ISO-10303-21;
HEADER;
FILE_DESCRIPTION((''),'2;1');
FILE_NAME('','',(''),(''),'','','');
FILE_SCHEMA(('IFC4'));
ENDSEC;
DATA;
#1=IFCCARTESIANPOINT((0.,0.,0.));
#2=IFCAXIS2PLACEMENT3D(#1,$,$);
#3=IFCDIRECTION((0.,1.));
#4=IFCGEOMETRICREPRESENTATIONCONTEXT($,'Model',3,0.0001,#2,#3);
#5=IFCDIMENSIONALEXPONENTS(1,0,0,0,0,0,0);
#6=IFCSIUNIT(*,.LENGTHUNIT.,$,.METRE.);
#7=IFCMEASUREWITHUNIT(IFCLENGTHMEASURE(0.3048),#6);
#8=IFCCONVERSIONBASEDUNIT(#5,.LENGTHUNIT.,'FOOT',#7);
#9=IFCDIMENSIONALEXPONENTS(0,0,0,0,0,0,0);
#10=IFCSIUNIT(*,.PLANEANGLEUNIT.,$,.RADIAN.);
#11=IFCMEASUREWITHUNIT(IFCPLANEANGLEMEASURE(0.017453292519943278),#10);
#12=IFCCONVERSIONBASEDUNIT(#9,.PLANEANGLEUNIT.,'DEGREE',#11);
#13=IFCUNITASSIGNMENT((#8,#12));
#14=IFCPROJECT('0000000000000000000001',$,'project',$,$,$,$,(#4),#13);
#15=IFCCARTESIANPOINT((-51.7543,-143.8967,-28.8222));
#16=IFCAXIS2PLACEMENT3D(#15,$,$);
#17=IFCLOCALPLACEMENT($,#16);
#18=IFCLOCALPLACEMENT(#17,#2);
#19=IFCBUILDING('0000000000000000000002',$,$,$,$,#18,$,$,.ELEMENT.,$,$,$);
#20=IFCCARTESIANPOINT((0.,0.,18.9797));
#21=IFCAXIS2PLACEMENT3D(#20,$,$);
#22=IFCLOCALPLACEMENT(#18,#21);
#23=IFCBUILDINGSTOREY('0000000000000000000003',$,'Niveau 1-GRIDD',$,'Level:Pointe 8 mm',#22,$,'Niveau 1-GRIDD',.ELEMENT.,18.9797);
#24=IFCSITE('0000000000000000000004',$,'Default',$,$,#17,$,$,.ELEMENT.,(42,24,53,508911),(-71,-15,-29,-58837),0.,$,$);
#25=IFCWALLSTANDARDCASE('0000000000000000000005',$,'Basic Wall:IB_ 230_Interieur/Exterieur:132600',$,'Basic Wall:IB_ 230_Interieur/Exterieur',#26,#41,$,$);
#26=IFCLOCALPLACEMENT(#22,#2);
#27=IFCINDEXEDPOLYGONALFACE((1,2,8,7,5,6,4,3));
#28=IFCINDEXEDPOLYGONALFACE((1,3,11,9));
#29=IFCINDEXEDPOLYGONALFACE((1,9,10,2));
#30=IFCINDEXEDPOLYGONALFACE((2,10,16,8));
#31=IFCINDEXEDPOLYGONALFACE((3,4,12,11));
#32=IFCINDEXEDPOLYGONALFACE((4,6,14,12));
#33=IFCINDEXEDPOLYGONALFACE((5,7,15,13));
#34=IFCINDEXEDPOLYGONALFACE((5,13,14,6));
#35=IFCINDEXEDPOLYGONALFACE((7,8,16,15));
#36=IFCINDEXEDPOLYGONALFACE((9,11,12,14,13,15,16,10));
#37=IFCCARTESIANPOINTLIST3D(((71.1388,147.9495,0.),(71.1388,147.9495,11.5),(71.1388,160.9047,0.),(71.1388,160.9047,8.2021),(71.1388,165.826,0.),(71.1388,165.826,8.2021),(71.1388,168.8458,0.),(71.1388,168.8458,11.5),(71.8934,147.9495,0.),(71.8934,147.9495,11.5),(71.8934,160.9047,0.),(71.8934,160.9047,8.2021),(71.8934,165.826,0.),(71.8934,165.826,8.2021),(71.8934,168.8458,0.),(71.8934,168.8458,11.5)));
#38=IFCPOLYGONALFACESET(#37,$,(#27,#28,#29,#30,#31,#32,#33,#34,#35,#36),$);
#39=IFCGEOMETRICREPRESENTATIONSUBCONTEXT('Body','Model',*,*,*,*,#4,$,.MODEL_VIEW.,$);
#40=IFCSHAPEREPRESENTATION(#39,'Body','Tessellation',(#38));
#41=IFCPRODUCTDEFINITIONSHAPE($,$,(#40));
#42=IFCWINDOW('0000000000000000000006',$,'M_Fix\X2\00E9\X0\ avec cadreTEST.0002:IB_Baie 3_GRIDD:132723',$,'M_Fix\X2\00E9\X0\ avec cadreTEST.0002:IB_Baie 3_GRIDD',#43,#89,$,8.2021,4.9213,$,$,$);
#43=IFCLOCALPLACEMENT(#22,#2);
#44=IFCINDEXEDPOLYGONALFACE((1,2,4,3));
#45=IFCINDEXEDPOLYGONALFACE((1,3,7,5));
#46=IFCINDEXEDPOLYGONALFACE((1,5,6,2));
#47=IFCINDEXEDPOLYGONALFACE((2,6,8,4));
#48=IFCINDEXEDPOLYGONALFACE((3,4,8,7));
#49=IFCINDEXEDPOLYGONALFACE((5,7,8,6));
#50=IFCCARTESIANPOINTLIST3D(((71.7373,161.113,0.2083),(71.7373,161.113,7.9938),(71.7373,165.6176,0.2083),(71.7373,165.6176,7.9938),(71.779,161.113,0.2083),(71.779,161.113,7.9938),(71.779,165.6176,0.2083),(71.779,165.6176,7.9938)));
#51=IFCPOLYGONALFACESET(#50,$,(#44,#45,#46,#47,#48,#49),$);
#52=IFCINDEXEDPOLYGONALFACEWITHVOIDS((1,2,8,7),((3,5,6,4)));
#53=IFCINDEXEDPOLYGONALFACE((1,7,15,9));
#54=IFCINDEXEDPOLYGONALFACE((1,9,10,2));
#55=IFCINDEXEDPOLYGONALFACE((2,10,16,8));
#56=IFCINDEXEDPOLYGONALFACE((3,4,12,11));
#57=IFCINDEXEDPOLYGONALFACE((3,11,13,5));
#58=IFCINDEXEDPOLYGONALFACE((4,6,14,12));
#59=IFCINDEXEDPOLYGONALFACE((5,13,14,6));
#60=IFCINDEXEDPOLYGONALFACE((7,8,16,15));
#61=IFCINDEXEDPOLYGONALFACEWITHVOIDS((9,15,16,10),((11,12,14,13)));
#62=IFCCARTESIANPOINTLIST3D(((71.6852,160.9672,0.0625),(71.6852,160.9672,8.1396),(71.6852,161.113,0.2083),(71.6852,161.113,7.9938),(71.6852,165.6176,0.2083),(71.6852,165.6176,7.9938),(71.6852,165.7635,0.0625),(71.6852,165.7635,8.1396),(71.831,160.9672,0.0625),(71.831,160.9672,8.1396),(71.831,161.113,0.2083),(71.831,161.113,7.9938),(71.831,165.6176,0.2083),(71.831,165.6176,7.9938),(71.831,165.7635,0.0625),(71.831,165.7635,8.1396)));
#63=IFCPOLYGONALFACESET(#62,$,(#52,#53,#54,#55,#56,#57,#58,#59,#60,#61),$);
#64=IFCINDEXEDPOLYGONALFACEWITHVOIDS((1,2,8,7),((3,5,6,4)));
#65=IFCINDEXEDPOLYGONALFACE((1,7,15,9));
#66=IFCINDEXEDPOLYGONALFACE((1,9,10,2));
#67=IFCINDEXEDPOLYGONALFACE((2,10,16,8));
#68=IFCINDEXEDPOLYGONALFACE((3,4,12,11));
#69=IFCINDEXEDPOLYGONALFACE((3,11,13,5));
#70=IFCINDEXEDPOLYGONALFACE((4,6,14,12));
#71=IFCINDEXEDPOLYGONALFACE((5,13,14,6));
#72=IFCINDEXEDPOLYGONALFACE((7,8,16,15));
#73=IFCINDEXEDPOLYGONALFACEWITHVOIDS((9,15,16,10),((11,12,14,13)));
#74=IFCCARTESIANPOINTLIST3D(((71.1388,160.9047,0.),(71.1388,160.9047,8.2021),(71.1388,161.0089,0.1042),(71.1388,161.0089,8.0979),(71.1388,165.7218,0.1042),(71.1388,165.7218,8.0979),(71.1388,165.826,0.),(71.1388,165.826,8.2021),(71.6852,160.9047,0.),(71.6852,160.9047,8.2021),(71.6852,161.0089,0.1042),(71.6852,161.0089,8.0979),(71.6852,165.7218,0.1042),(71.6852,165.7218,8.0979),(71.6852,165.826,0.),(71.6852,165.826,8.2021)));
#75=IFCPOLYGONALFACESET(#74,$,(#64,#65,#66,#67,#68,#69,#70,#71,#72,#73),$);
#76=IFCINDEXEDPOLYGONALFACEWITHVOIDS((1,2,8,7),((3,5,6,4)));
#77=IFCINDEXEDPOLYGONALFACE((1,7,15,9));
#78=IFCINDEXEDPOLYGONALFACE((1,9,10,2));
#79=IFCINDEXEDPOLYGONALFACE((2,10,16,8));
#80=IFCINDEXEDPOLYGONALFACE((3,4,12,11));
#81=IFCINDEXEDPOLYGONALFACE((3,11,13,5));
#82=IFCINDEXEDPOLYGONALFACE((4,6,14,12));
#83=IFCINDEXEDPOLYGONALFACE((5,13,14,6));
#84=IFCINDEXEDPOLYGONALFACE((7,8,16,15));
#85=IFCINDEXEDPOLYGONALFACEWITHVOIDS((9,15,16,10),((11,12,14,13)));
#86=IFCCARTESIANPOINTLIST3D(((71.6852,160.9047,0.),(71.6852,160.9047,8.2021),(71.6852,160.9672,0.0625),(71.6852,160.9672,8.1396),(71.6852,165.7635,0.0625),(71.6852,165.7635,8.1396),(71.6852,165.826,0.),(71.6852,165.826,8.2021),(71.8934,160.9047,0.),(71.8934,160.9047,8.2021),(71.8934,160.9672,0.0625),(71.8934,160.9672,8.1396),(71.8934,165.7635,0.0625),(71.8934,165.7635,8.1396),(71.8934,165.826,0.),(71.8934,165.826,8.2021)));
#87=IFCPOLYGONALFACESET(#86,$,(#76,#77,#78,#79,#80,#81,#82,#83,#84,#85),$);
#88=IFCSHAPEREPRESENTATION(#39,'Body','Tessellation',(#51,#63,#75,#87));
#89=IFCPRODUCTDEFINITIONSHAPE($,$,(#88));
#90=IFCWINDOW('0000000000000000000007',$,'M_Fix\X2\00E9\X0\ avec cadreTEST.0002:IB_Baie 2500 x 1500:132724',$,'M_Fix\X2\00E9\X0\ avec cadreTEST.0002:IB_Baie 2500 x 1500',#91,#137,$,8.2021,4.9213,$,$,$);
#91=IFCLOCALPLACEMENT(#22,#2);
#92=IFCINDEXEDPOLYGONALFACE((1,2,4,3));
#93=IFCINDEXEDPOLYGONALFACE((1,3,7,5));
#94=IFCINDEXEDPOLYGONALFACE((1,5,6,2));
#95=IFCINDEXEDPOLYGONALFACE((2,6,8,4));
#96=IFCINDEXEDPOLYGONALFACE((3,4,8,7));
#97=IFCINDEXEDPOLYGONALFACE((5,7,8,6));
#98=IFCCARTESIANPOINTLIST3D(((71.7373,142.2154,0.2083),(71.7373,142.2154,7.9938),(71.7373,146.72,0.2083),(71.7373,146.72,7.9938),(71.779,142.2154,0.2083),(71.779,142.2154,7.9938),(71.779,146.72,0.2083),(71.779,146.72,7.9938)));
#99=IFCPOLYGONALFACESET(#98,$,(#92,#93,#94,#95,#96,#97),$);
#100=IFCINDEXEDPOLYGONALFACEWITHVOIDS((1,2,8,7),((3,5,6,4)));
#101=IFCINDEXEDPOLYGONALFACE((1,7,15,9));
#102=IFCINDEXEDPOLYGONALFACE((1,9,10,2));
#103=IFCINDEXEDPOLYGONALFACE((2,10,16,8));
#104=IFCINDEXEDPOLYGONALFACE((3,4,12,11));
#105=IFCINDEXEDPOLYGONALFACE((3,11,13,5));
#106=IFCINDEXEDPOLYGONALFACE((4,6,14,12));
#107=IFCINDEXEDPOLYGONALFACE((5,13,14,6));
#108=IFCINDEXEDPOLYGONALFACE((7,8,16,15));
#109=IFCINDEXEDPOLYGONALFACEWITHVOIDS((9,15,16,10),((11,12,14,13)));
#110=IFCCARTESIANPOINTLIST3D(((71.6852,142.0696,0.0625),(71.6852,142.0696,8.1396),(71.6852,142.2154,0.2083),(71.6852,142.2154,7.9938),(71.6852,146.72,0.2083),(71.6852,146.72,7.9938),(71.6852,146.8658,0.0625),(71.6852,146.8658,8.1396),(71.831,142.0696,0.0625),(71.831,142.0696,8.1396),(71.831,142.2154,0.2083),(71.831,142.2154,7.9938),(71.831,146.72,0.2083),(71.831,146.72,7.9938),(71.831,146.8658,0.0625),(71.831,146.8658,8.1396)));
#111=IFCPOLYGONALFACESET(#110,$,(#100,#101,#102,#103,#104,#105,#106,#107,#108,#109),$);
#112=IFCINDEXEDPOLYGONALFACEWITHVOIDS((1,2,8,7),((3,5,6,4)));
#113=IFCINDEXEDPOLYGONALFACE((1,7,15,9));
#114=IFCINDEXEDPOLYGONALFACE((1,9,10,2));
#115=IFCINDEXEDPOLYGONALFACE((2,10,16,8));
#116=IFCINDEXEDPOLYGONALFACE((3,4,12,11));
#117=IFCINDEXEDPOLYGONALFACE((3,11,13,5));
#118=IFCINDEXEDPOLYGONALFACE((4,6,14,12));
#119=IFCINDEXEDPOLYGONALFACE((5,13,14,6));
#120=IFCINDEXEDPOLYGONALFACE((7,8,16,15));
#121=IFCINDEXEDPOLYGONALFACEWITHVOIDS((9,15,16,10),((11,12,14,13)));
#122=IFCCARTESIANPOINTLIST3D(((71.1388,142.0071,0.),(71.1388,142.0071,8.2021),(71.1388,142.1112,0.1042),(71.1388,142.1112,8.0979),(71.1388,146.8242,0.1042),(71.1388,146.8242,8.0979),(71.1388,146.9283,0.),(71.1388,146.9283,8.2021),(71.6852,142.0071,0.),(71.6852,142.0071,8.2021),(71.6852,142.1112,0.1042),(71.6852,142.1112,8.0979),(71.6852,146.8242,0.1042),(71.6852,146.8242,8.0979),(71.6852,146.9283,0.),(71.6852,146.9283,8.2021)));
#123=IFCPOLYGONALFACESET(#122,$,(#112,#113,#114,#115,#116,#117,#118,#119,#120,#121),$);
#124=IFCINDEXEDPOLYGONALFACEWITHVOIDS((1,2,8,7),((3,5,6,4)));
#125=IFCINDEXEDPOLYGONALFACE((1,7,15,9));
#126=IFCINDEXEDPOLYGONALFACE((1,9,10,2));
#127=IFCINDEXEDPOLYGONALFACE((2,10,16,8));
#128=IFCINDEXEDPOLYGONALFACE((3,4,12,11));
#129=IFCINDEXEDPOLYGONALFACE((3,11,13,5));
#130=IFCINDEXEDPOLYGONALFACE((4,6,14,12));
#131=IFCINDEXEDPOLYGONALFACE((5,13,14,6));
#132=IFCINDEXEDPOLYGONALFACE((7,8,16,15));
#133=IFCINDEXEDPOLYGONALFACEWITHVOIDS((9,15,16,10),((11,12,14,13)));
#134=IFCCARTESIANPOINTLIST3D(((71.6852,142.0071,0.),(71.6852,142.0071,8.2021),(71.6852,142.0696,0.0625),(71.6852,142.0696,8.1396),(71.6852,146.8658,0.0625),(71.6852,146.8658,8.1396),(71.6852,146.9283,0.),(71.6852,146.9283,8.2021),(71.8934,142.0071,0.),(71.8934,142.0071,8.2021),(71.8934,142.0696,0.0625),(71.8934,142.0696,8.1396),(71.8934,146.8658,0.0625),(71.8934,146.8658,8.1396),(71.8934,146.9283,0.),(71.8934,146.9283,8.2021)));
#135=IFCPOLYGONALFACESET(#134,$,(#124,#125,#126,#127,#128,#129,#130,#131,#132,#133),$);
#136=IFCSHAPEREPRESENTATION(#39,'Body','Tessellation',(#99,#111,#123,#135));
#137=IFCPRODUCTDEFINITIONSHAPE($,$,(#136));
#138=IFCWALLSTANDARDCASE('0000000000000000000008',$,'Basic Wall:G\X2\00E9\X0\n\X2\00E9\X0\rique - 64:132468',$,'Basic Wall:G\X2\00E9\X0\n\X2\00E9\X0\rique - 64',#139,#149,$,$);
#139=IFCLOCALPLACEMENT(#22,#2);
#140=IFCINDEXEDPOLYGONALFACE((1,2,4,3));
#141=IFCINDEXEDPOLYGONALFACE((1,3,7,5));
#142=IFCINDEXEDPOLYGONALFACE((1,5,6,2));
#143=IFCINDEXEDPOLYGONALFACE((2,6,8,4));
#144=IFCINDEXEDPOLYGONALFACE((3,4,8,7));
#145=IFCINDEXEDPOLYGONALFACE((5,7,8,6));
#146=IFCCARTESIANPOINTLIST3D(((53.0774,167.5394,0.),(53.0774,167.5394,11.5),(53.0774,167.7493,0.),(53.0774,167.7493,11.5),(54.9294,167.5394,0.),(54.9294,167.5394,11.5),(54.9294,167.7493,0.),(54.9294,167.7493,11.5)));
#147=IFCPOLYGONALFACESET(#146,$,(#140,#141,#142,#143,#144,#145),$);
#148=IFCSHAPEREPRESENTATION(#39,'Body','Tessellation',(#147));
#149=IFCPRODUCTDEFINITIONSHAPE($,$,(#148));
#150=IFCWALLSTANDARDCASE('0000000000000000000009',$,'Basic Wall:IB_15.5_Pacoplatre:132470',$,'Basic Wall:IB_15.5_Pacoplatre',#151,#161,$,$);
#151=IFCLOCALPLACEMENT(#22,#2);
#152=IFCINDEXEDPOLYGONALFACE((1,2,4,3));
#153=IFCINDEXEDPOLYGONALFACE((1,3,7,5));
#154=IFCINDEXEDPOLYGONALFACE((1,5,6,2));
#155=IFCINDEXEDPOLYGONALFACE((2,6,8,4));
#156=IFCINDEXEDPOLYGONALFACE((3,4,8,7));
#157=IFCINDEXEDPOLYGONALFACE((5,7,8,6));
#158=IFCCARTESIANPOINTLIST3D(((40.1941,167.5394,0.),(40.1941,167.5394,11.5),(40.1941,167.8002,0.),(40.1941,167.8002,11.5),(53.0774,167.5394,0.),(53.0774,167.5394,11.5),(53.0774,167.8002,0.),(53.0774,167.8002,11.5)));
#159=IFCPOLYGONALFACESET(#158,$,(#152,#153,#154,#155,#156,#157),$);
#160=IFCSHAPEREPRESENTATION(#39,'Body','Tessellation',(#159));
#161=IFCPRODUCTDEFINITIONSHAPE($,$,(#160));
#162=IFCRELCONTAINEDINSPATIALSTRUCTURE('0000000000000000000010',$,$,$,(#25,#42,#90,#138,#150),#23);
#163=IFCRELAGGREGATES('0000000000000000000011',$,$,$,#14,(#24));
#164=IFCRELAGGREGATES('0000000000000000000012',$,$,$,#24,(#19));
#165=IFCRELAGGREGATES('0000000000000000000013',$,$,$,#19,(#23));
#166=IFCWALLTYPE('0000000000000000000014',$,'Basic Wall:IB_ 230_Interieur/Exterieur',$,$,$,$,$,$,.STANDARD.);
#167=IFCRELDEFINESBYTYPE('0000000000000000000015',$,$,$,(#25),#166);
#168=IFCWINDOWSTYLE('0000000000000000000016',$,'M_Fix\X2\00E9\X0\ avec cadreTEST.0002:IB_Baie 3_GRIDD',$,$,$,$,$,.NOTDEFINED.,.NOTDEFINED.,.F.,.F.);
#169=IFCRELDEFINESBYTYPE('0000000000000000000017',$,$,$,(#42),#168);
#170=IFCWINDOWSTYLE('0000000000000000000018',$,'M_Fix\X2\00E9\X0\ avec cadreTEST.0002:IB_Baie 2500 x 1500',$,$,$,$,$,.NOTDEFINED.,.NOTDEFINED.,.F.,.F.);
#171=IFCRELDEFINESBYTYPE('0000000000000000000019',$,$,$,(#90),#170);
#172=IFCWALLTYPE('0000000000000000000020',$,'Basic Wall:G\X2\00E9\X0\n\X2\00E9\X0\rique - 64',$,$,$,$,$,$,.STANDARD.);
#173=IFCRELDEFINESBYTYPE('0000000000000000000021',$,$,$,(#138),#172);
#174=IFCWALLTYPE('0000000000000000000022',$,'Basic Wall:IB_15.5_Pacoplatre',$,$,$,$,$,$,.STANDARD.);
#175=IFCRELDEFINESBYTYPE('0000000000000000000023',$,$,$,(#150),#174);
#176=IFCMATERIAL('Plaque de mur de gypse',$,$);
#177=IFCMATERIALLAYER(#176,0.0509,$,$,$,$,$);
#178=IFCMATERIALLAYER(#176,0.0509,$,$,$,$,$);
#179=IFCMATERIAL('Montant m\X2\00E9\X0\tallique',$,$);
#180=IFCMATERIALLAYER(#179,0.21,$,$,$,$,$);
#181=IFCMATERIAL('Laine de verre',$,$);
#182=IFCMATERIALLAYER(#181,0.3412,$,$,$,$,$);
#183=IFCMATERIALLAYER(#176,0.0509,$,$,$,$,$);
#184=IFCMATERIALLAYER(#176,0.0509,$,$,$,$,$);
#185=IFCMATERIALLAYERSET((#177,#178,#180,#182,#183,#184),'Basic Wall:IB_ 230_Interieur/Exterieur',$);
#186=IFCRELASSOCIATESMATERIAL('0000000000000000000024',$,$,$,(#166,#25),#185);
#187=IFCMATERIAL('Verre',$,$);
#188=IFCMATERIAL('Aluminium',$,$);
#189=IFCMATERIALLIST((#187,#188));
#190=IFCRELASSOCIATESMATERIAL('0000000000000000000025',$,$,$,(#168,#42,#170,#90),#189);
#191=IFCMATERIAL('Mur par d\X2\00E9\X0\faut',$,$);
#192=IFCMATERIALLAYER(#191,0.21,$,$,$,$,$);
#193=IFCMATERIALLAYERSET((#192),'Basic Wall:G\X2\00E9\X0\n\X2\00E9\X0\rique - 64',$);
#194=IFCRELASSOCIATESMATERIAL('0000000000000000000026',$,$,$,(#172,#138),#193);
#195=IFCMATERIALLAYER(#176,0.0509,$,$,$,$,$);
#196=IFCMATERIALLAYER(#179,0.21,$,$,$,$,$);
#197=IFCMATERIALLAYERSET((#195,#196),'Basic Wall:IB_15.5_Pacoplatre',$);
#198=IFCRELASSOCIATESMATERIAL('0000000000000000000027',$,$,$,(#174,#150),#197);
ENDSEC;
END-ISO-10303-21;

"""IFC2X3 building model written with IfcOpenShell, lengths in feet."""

from ifc_helpers import new_model, entity, si_unit, converted_unit, direction, frame, frame_2d, origin, place, context, subcontext, project, spatial, polyline, rectangle, outline, extrude, clip, bounded_halfspace, source, transform, mapped, material, material_list, layer, layer_set, layer_usage, type_object, type_shapes, element, fill, save


model = new_model("IFC2X3")

# Units and contexts
model_context = context("Model", 3, precision=0.0001, world=origin(), true_north=direction((0.0, 1.0)))
body_context = subcontext(model_context, "Body", "Model", "MODEL_VIEW")
ifc_project = project(units=[converted_unit("LENGTHUNIT", "FOOT", entity("IfcLengthMeasure", 0.3048), si_unit("LENGTHUNIT", "METRE"), dimensions=[1, 0, 0, 0, 0, 0, 0]), converted_unit("PLANEANGLEUNIT", "DEGREE", entity("IfcPlaneAngleMeasure", 0.017453292519943278), si_unit("PLANEANGLEUNIT", "RADIAN"), dimensions=[0, 0, 0, 0, 0, 0, 0])], contexts=[model_context])

# Site, building, storey
site_placement = place(None, frame((-51.7543, -143.8967, -28.8222)))
site = spatial("IfcSite", under=ifc_project, at=site_placement, Name="Default", CompositionType="ELEMENT", RefLatitude=(42, 24, 53, 508911), RefLongitude=(-71, -15, -29, -58837), RefElevation=0.0)
building_placement = place(site_placement, origin())
building = spatial("IfcBuilding", under=site, at=building_placement, CompositionType="ELEMENT")
storey_placement = place(building_placement, frame((0.0, 0.0, 18.9797)))
storey = spatial("IfcBuildingStorey", under=building, at=storey_placement, Name="Niveau 1-GRIDD", ObjectType="Level:Pointe 8 mm", LongName="Niveau 1-GRIDD", CompositionType="ELEMENT", Elevation=18.9797)

# Wall, openings, windows
ifc_material_1 = material(Name="Plaque de mur de gypse")
ifc_layer_1 = layer(ifc_material_1, 0.0509)
ifc_layer_2 = layer(ifc_material_1, 0.0509)
ifc_material_2 = material(Name="Montant métallique")
ifc_layer_3 = layer(ifc_material_2, 0.21)
ifc_material_3 = material(Name="Laine de verre")
ifc_layer_4 = layer(ifc_material_3, 0.3412)
ifc_layer_5 = layer(ifc_material_1, 0.0509)
ifc_layer_6 = layer(ifc_material_1, 0.0509)
ifc_layer_set_1 = layer_set([ifc_layer_1, ifc_layer_2, ifc_layer_3, ifc_layer_4, ifc_layer_5, ifc_layer_6], Name="Basic Wall:IB_ 230_Interieur/Exterieur")
ifc_layer_usage_1 = layer_usage(ifc_layer_set_1, "AXIS2", "NEGATIVE", 0.3773)
wall_type_1 = type_object("IfcWallType", Name="Basic Wall:IB_ 230_Interieur/Exterieur", PredefinedType="STANDARD", material=ifc_layer_set_1)
wall_1_placement = place(storey_placement, frame((71.5161, 168.8458, 0.0), z_axis=(0.0, 0.0, 1.0), x_axis=(0.0, -1.0, 0.0)))
wall_1 = element("IfcWallStandardCase", 1, at=wall_1_placement, inside=storey, type_object=wall_type_1, material=ifc_layer_usage_1, Name="Basic Wall:IB_ 230_Interieur/Exterieur:132600", ObjectType="Basic Wall:IB_ 230_Interieur/Exterieur", context=body_context, shape_type="Clipping", body=[
    clip(extrude(outline(polyline([(0.0, -0.3773), (20.8963, -0.3773), (20.8963, 0.3773), (0.0, 0.3773), (0.0, -0.3773)]), holes=[polyline([(26.8387, -0.3773), (21.9175, -0.3773), (21.9175, 0.3773), (26.8387, 0.3773), (26.8387, -0.3773)])]), origin(), (0.0, 0.0, 1.0), 11.5), bounded_halfspace(frame((20.8963, -0.3773, 11.5), z_axis=(-1.0, 0.0, 0.0), x_axis=(0.0, 1.0, 0.0)), True, frame((20.8963, -0.3773, 11.5), z_axis=(-1.0, 0.0, 0.0), x_axis=(0.0, 1.0, 0.0)), polyline([(0.0, 0.0), (0.7546, 0.0), (0.7546, 11.5), (0.0, 11.5), (0.0, 0.0)]))),
])
opening_1_placement = place(wall_1_placement, origin())
element("IfcOpeningElement", 2, at=opening_1_placement, cuts=wall_1, ObjectType="Opening", context=body_context, shape_type="SweptSolid", body=[
    extrude(rectangle(XDim=7.0, YDim=3.7484, at=frame_2d((0.0, 0.0), x_axis=(0.0, 1.0))), frame((6.0296, 0.3773, 3.5), z_axis=(0.0, -1.0, 0.0), x_axis=(1.0, 0.0, 0.0)), (0.0, 0.0, 1.0), 0.7546),
])
opening_2_placement = place(wall_1_placement, frame((3.0198, -0.3773, 0.0)))
opening_2 = element("IfcOpeningElement", 3, at=opening_2_placement, cuts=wall_1, ObjectType="Opening", context=body_context, shape_type="SweptSolid", body=[
    extrude(rectangle(XDim=8.2021, YDim=4.9213, at=frame_2d((4.101, 2.4606), x_axis=(-1.0, 0.0))), frame((0.0, 0.0, 0.0), z_axis=(0.0, 1.0, 0.0), x_axis=(0.0, 0.0, 1.0)), (0.0, 0.0, 1.0), 0.7546),
])
opening_3_placement = place(wall_1_placement, frame((21.9175, -0.3773, 0.0)))
opening_3 = element("IfcOpeningElement", 4, at=opening_3_placement, cuts=wall_1, ObjectType="Opening", context=body_context, shape_type="SweptSolid", body=[
    extrude(rectangle(XDim=8.2021, YDim=4.9213, at=frame_2d((4.101, 2.4606), x_axis=(-1.0, 0.0))), frame((0.0, 0.0, 0.0), z_axis=(0.0, 1.0, 0.0), x_axis=(0.0, 0.0, 1.0)), (0.0, 0.0, 1.0), 0.7546),
])
ifc_material_4 = material(Name="Verre")
ifc_material_5 = material(Name="Aluminium")
ifc_material_list_1 = material_list([ifc_material_4, ifc_material_5])
window_style_1 = type_object("IfcWindowStyle", Name="M_Fixé avec cadreTEST.0002:IB_Baie 3_GRIDD", ConstructionType="NOTDEFINED", OperationType="NOTDEFINED", ParameterTakesPrecedence=False, Sizeable=False, material=ifc_material_list_1)
shared_shape_1 = source(origin(), body_context, "Body", "SweptSolid", [
    extrude(rectangle(XDim=0.0417, YDim=4.5046, at=frame_2d((0.0, 0.0), x_axis=(1.0, 0.0))), frame((2.4606, 0.6193, 0.2083), z_axis=(0.0, 0.0, 1.0), x_axis=(0.0, 1.0, 0.0)), (0.0, 0.0, 1.0), 7.7854),
    extrude(outline(polyline([(-2.3981, -4.0385), (2.3981, -4.0385), (2.3981, 4.0385), (-2.3981, 4.0385), (-2.3981, -4.0385)]), holes=[polyline([(-2.2523, -3.8927), (-2.2523, 3.8927), (2.2523, 3.8927), (2.2523, -3.8927), (-2.2523, -3.8927)])]), frame((2.4606, 0.5464, 4.101), z_axis=(0.0, 1.0, 0.0), x_axis=(1.0, 0.0, 0.0)), (0.0, 0.0, 1.0), 0.1458),
    extrude(outline(polyline([(-2.4606, -4.101), (2.4606, -4.101), (2.4606, 4.101), (-2.4606, 4.101), (-2.4606, -4.101)]), holes=[polyline([(-2.3565, -3.9969), (-2.3565, 3.9969), (2.3565, 3.9969), (2.3565, -3.9969), (-2.3565, -3.9969)])]), frame((2.4606, 0.0, 4.101), z_axis=(0.0, 1.0, 0.0), x_axis=(1.0, 0.0, 0.0)), (0.0, 0.0, 1.0), 0.5464),
    extrude(outline(polyline([(-4.101, -2.4606), (4.101, -2.4606), (4.101, 2.4606), (-4.101, 2.4606), (-4.101, -2.4606)]), holes=[polyline([(-4.0385, -2.3981), (-4.0385, 2.3981), (4.0385, 2.3981), (4.0385, -2.3981), (-4.0385, -2.3981)])]), frame((2.4606, 0.5464, 4.101), z_axis=(0.0, 1.0, 0.0), x_axis=(0.0, 0.0, -1.0)), (0.0, 0.0, 1.0), 0.2082),
])
type_shapes(window_style_1, [shared_shape_1])
window_1_placement = place(opening_2_placement, origin())
window_1 = element("IfcWindow", 5, at=window_1_placement, inside=storey, type_object=window_style_1, material=ifc_material_list_1, Name="M_Fixé avec cadreTEST.0002:IB_Baie 3_GRIDD:132723", ObjectType="M_Fixé avec cadreTEST.0002:IB_Baie 3_GRIDD", OverallHeight=8.2021, OverallWidth=4.9213, context=body_context, shape_type="MappedRepresentation", body=[
    mapped(shared_shape_1, transform((0.0, 0.0, 0.0), scale=1.0)),
])
fill(opening_2, window_1)
window_style_2 = type_object("IfcWindowStyle", Name="M_Fixé avec cadreTEST.0002:IB_Baie 2500 x 1500", ConstructionType="NOTDEFINED", OperationType="NOTDEFINED", ParameterTakesPrecedence=False, Sizeable=False, material=ifc_material_list_1)
shared_shape_2 = source(origin(), body_context, "Body", "SweptSolid", [
    extrude(rectangle(XDim=0.0417, YDim=4.5046, at=frame_2d((0.0, 0.0), x_axis=(1.0, 0.0))), frame((2.4606, 0.6193, 0.2083), z_axis=(0.0, 0.0, 1.0), x_axis=(0.0, 1.0, 0.0)), (0.0, 0.0, 1.0), 7.7854),
    extrude(outline(polyline([(-2.3981, -4.0385), (2.3981, -4.0385), (2.3981, 4.0385), (-2.3981, 4.0385), (-2.3981, -4.0385)]), holes=[polyline([(-2.2523, -3.8927), (-2.2523, 3.8927), (2.2523, 3.8927), (2.2523, -3.8927), (-2.2523, -3.8927)])]), frame((2.4606, 0.5464, 4.101), z_axis=(0.0, 1.0, 0.0), x_axis=(1.0, 0.0, 0.0)), (0.0, 0.0, 1.0), 0.1458),
    extrude(outline(polyline([(-2.4606, -4.101), (2.4606, -4.101), (2.4606, 4.101), (-2.4606, 4.101), (-2.4606, -4.101)]), holes=[polyline([(-2.3565, -3.9969), (-2.3565, 3.9969), (2.3565, 3.9969), (2.3565, -3.9969), (-2.3565, -3.9969)])]), frame((2.4606, 0.0, 4.101), z_axis=(0.0, 1.0, 0.0), x_axis=(1.0, 0.0, 0.0)), (0.0, 0.0, 1.0), 0.5464),
    extrude(outline(polyline([(-4.101, -2.4606), (4.101, -2.4606), (4.101, 2.4606), (-4.101, 2.4606), (-4.101, -2.4606)]), holes=[polyline([(-4.0385, -2.3981), (-4.0385, 2.3981), (4.0385, 2.3981), (4.0385, -2.3981), (-4.0385, -2.3981)])]), frame((2.4606, 0.5464, 4.101), z_axis=(0.0, 1.0, 0.0), x_axis=(0.0, 0.0, -1.0)), (0.0, 0.0, 1.0), 0.2082),
])
type_shapes(window_style_2, [shared_shape_2])
window_2_placement = place(opening_3_placement, origin())
window_2 = element("IfcWindow", 6, at=window_2_placement, inside=storey, type_object=window_style_2, material=ifc_material_list_1, Name="M_Fixé avec cadreTEST.0002:IB_Baie 2500 x 1500:132724", ObjectType="M_Fixé avec cadreTEST.0002:IB_Baie 2500 x 1500", OverallHeight=8.2021, OverallWidth=4.9213, context=body_context, shape_type="MappedRepresentation", body=[
    mapped(shared_shape_2, transform((0.0, 0.0, 0.0), scale=1.0)),
])
fill(opening_3, window_2)

# Walls
ifc_material_6 = material(Name="Mur par défaut")
ifc_layer_7 = layer(ifc_material_6, 0.21)
ifc_layer_set_2 = layer_set([ifc_layer_7], Name="Basic Wall:Générique - 64")
ifc_layer_usage_2 = layer_usage(ifc_layer_set_2, "AXIS2", "POSITIVE", -0.105)
wall_type_2 = type_object("IfcWallType", Name="Basic Wall:Générique - 64", PredefinedType="STANDARD", material=ifc_layer_set_2)
wall_2_placement = place(storey_placement, frame((53.0774, 167.6444, 0.0)))
element("IfcWallStandardCase", 7, at=wall_2_placement, inside=storey, type_object=wall_type_2, material=ifc_layer_usage_2, Name="Basic Wall:Générique - 64:132468", ObjectType="Basic Wall:Générique - 64", context=body_context, shape_type="SweptSolid", body=[
    extrude(rectangle(XDim=1.852, YDim=0.21, at=frame_2d((0.926, 0.0), x_axis=(-1.0, 0.0))), origin(), (0.0, 0.0, 1.0), 11.5),
])
ifc_layer_8 = layer(ifc_material_1, 0.0509)
ifc_layer_9 = layer(ifc_material_2, 0.21)
ifc_layer_set_3 = layer_set([ifc_layer_8, ifc_layer_9], Name="Basic Wall:IB_15.5_Pacoplatre")
ifc_layer_usage_3 = layer_usage(ifc_layer_set_3, "AXIS2", "POSITIVE", -0.1304)
wall_type_3 = type_object("IfcWallType", Name="Basic Wall:IB_15.5_Pacoplatre", PredefinedType="STANDARD", material=ifc_layer_set_3)
wall_3_placement = place(storey_placement, frame((53.0774, 167.6698, 0.0), z_axis=(0.0, 0.0, 1.0), x_axis=(-1.0, 0.0, 0.0)))
element("IfcWallStandardCase", 8, at=wall_3_placement, inside=storey, type_object=wall_type_3, material=ifc_layer_usage_3, Name="Basic Wall:IB_15.5_Pacoplatre:132470", ObjectType="Basic Wall:IB_15.5_Pacoplatre", context=body_context, shape_type="SweptSolid", body=[
    extrude(rectangle(XDim=12.8834, YDim=0.2608, at=frame_2d((6.4417, 0.0), x_axis=(-1.0, 0.0))), origin(), (0.0, 0.0, 1.0), 11.5),
])

save(model, "model.ifc")
